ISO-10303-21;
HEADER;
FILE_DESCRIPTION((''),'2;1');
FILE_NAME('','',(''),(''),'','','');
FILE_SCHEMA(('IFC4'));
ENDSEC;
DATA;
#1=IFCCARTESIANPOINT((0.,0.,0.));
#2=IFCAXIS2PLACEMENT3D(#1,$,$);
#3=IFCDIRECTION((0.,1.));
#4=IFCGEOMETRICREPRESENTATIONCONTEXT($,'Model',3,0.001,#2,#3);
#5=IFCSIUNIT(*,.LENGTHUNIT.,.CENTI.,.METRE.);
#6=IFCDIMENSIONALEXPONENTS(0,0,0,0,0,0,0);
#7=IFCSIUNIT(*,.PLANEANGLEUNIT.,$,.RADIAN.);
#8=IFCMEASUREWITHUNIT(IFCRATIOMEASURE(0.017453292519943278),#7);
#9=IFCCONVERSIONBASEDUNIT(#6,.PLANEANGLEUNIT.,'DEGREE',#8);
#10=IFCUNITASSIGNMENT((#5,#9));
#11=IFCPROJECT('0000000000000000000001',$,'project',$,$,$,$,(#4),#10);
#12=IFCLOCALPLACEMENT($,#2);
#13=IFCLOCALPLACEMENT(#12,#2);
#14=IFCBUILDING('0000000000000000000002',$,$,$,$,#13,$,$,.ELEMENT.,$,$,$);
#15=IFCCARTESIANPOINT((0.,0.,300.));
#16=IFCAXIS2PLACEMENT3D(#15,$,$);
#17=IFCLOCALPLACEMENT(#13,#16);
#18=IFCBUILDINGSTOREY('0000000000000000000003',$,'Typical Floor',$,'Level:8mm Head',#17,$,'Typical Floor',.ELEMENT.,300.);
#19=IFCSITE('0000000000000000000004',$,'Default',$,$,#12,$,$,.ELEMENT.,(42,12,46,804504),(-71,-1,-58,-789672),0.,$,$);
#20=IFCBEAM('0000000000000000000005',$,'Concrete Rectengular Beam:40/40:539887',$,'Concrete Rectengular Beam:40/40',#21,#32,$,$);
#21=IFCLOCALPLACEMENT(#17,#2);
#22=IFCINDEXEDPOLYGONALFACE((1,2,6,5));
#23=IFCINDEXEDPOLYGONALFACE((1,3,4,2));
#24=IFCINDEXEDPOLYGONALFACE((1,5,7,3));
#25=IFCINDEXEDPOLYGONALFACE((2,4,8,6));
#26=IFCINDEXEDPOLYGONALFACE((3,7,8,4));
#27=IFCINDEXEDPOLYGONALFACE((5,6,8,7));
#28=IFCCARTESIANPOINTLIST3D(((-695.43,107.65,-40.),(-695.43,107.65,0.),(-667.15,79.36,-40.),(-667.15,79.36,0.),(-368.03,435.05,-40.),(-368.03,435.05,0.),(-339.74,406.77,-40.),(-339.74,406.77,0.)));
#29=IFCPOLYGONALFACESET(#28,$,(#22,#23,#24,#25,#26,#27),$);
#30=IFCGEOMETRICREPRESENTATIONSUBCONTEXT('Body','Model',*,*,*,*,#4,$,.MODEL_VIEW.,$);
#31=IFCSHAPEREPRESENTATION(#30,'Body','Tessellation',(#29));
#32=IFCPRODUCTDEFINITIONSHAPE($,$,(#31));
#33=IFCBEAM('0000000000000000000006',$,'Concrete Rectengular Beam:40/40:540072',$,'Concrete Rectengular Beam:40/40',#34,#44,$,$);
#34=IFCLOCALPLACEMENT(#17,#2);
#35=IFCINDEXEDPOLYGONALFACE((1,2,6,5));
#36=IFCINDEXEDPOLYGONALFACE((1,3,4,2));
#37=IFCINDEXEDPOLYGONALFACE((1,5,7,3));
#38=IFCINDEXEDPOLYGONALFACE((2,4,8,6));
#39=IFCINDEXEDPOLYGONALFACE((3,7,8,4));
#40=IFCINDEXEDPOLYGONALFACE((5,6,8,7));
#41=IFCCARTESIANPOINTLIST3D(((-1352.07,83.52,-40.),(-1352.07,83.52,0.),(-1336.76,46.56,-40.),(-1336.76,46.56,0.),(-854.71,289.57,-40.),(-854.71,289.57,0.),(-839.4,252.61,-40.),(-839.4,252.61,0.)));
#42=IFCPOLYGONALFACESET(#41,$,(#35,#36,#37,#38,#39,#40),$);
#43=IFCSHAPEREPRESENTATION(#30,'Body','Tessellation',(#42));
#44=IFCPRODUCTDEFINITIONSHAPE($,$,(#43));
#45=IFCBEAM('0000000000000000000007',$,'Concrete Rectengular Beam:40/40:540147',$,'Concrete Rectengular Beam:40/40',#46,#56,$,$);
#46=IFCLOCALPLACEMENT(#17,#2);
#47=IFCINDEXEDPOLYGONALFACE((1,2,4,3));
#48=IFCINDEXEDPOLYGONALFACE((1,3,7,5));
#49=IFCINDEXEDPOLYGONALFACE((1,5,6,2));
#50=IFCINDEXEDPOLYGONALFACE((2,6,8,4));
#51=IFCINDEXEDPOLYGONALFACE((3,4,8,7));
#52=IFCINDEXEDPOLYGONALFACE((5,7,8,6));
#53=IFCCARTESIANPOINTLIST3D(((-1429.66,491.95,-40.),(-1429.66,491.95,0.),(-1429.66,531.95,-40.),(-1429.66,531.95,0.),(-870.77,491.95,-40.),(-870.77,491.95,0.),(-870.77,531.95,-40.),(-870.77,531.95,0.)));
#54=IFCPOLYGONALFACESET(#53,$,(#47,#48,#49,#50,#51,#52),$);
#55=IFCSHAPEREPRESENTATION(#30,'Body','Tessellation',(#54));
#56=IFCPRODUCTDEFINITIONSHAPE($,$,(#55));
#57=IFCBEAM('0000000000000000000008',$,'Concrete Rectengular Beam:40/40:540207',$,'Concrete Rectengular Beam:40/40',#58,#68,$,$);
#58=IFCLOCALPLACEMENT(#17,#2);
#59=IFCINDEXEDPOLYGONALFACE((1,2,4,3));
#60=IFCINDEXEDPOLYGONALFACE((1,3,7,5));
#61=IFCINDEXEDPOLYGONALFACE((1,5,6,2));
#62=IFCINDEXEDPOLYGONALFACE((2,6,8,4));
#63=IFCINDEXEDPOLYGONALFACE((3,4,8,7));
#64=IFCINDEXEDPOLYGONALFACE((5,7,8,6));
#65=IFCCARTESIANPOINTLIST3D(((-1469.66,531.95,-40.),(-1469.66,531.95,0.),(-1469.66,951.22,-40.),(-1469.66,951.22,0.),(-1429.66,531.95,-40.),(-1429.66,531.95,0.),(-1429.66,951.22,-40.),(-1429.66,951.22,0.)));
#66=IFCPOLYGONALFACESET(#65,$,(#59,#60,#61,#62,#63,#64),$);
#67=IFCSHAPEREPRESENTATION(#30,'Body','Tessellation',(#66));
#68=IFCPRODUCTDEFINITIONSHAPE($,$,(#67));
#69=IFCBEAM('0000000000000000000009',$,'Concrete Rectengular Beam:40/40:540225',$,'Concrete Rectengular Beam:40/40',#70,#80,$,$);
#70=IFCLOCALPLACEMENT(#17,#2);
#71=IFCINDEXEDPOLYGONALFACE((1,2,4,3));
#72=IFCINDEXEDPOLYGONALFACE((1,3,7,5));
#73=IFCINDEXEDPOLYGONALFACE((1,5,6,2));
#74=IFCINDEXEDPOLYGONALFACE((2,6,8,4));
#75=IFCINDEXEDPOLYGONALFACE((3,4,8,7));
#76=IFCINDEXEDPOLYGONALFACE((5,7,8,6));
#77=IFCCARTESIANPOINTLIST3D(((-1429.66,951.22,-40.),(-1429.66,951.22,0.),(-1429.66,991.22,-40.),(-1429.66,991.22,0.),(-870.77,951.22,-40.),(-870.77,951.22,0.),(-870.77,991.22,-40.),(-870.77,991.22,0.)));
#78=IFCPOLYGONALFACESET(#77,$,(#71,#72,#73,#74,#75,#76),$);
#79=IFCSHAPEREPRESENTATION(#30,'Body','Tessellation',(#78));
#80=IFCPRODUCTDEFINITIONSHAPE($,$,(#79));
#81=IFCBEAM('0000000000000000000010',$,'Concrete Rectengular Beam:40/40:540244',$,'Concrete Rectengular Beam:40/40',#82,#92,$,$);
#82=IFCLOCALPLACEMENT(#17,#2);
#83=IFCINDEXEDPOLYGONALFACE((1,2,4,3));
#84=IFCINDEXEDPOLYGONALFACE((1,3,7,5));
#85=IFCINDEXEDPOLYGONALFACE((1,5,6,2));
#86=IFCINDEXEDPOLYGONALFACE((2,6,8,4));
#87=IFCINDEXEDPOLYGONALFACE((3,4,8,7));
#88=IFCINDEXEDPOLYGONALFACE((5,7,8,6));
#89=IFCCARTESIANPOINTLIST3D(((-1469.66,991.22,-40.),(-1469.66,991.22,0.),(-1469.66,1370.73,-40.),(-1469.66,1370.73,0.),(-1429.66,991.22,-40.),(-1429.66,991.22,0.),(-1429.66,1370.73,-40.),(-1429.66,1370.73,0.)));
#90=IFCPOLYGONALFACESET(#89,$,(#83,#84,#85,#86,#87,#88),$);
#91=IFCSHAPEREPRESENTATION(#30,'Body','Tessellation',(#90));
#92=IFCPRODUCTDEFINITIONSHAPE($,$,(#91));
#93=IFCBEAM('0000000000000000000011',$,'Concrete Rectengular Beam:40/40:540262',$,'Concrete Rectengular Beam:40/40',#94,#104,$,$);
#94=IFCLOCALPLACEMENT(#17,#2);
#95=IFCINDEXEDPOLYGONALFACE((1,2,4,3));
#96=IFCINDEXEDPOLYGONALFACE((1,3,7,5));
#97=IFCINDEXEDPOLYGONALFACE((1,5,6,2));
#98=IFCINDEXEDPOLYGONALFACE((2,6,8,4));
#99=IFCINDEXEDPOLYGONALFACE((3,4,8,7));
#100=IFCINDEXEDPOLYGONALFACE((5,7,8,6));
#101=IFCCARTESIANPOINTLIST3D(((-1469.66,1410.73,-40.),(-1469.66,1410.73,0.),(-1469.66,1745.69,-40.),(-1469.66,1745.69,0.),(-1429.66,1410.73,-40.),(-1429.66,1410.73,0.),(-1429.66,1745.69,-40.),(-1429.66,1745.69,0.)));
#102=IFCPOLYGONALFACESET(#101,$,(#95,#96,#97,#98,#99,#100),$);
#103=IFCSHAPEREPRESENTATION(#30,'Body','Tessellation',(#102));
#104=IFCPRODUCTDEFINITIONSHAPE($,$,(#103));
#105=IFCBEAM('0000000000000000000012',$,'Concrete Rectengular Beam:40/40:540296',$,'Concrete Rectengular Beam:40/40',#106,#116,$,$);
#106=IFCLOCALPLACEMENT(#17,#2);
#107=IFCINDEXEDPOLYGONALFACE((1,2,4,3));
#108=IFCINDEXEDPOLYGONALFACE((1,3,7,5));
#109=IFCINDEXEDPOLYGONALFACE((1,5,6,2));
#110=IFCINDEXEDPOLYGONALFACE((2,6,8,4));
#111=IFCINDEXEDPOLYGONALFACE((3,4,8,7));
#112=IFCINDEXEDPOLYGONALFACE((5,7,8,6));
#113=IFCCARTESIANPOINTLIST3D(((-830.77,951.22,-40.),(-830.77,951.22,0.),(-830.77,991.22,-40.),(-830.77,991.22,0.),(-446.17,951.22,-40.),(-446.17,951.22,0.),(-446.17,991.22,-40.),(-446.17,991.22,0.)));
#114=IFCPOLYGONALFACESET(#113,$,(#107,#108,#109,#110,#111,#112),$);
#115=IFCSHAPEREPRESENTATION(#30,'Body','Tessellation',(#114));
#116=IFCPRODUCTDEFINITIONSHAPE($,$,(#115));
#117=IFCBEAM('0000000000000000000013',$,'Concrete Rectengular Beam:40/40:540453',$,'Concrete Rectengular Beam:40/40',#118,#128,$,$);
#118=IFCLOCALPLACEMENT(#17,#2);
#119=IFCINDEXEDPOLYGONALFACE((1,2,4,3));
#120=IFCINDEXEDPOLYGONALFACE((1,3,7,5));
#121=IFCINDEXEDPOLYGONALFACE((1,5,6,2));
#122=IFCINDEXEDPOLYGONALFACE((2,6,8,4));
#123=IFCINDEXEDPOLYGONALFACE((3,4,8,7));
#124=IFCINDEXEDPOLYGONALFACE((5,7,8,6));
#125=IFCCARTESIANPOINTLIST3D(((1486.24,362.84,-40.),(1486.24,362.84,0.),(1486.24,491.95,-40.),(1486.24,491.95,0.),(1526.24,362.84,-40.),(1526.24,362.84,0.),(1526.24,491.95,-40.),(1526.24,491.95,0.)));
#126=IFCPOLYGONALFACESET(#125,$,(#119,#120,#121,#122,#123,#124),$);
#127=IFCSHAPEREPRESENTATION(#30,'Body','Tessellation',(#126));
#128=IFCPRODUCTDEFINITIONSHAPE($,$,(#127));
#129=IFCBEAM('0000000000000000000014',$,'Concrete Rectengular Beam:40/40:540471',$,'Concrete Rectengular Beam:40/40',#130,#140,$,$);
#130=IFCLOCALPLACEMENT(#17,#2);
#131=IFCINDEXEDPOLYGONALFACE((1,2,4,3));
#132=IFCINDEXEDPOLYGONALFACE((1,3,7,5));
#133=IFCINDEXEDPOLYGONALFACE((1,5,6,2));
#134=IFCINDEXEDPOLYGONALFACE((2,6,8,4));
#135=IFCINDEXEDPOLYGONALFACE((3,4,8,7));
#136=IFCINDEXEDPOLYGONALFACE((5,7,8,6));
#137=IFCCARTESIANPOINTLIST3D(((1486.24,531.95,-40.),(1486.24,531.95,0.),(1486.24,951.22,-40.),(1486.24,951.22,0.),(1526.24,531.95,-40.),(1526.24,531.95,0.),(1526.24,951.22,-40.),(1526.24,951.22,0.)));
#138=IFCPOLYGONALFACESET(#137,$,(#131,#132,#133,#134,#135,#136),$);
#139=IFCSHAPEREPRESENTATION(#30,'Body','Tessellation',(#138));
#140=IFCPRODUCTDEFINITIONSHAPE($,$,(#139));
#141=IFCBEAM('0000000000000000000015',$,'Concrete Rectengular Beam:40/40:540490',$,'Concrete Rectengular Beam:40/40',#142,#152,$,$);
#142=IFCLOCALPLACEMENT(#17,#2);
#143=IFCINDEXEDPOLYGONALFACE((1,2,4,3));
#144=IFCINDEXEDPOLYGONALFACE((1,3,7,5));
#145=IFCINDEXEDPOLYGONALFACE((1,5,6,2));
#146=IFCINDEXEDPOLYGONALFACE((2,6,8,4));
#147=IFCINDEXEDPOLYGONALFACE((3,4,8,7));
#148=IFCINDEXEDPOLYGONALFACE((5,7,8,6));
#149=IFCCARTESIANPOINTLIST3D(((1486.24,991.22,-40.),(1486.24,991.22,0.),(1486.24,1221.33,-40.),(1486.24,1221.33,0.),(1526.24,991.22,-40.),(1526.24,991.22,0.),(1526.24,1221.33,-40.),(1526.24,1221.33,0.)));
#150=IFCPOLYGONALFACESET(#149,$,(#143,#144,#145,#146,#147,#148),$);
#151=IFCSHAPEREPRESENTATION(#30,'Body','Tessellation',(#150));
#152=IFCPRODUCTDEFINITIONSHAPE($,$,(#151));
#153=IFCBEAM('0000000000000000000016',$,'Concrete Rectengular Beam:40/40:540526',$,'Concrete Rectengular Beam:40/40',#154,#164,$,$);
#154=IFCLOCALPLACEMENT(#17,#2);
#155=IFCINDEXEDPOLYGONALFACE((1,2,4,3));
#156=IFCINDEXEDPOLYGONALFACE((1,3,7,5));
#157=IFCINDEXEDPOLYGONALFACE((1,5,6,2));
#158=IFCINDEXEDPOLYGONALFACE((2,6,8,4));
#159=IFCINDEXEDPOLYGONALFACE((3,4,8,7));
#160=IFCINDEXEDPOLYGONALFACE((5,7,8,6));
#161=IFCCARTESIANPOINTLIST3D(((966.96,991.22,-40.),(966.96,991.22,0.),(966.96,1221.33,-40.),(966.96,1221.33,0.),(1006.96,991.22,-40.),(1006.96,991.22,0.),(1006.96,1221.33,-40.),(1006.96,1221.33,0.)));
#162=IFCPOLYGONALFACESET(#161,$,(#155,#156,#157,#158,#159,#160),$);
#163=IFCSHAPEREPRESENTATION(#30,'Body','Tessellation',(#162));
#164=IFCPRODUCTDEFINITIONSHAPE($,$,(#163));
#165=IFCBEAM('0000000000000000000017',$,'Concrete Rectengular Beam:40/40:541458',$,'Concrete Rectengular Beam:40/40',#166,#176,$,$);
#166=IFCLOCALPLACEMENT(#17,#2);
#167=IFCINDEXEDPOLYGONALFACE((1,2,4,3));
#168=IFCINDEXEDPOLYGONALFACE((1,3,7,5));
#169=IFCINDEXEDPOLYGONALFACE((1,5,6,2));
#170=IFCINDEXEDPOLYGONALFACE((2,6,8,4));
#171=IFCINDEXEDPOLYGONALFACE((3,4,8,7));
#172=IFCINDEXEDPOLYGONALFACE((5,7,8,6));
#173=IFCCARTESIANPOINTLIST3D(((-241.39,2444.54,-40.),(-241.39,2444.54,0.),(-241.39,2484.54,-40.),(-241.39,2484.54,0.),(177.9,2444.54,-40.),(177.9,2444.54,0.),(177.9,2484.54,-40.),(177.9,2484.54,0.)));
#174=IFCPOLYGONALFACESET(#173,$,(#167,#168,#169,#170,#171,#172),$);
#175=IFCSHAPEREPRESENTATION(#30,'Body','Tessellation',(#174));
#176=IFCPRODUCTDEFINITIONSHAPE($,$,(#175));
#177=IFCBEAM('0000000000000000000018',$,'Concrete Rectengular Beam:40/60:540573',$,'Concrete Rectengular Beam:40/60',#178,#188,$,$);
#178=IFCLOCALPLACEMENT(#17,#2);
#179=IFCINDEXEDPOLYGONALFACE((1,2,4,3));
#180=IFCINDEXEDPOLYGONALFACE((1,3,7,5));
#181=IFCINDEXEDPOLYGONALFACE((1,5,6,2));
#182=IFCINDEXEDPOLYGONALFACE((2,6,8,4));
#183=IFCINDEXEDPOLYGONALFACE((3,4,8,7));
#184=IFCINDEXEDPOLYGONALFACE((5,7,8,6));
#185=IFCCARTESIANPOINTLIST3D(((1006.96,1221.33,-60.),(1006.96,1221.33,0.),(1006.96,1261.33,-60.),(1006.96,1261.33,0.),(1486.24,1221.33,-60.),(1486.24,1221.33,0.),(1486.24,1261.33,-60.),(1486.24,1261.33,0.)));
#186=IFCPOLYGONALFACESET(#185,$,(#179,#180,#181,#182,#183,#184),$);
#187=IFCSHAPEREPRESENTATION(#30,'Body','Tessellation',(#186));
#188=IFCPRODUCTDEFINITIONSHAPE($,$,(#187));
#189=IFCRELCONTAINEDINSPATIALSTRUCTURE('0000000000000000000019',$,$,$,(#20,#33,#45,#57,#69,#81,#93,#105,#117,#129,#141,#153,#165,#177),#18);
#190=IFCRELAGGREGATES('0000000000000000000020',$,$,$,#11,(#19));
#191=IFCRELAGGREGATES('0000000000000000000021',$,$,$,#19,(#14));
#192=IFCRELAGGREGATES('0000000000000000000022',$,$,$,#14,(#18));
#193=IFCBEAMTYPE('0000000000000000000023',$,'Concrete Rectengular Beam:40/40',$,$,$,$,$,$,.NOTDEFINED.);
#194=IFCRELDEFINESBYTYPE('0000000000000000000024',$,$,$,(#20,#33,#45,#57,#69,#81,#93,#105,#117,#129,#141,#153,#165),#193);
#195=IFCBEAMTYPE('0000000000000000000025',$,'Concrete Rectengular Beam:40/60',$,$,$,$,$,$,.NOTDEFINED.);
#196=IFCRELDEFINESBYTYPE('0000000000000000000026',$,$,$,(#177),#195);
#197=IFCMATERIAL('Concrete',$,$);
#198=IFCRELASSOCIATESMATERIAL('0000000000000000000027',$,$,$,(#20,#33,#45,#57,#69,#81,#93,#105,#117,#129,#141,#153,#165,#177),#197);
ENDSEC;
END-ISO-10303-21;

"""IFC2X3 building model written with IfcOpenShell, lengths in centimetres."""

from ifc_helpers import new_model, entity, si_unit, converted_unit, direction, frame, frame_2d, origin, origin_2d_with_axis, place, context, subcontext, project, spatial, rectangle, extrude, material, type_object, element, save


model = new_model("IFC2X3")

# Units and contexts
model_context = context("Model", 3, precision=0.001, world=origin(), true_north=direction((0.0, 1.0)))
body_context = subcontext(model_context, "Body", "Model", "MODEL_VIEW")
ifc_project = project(units=[si_unit("LENGTHUNIT", "METRE", prefix="CENTI"), converted_unit("PLANEANGLEUNIT", "DEGREE", entity("IfcRatioMeasure", 0.017453292519943278), si_unit("PLANEANGLEUNIT", "RADIAN"), dimensions=[0, 0, 0, 0, 0, 0, 0])], contexts=[model_context])

# Site, building, storey
site_placement = place(None, origin())
site = spatial("IfcSite", under=ifc_project, at=site_placement, Name="Default", CompositionType="ELEMENT", RefLatitude=(42, 12, 46, 804504), RefLongitude=(-71, -1, -58, -789672), RefElevation=0.0)
building_placement = place(site_placement, origin())
building = spatial("IfcBuilding", under=site, at=building_placement, CompositionType="ELEMENT")
storey_placement = place(building_placement, frame((0.0, 0.0, 300.0)))
storey = spatial("IfcBuildingStorey", under=building, at=storey_placement, Name="Typical Floor", ObjectType="Level:8mm Head", LongName="Typical Floor", CompositionType="ELEMENT", Elevation=300.0)

# Beams
ifc_material = material(Name="Concrete")
beam_type_1 = type_object("IfcBeamType", Name="Concrete Rectengular Beam:40/40", PredefinedType="NOTDEFINED")
beam_1_placement = place(storey_placement, frame((-681.33, 93.46, 0.0), z_axis=(0.0, 0.0, 1.0), x_axis=(0.707109, 0.707104, 0.0)))
element("IfcBeam", 1, at=beam_1_placement, inside=storey, type_object=beam_type_1, material=ifc_material, Name="Concrete Rectengular Beam:40/40:539887", ObjectType="Concrete Rectengular Beam:40/40", context=body_context, shape_type="SweptSolid", body=[
    extrude(rectangle(XDim=40.0, YDim=40.0, at=frame_2d((0.0, 0.0), x_axis=(1.0, 0.0))), frame((0.06, 0.0, -20.0), z_axis=(1.0, 0.0, 0.0), x_axis=(0.0, 0.0, -1.0)), (0.0, 0.0, 1.0), 463.02),
])
beam_2_placement = place(storey_placement, frame((-1362.89, 57.39, 0.0), z_axis=(0.0, 0.0, 1.0), x_axis=(0.923857, 0.382737, 0.0)))
element("IfcBeam", 2, at=beam_2_placement, inside=storey, type_object=beam_type_1, material=ifc_material, Name="Concrete Rectengular Beam:40/40:540072", ObjectType="Concrete Rectengular Beam:40/40", context=body_context, shape_type="SweptSolid", body=[
    extrude(rectangle(XDim=40.0, YDim=40.0, at=frame_2d((0.0, 0.0), x_axis=(1.0, 0.0))), frame((20.0, 0.0, -20.0), z_axis=(1.0, 0.0, 0.0), x_axis=(0.0, 0.0, -1.0)), (0.0, 0.0, 1.0), 538.36),
])
beam_3_placement = place(storey_placement, frame((-1449.66, 511.95, 0.0)))
element("IfcBeam", 3, at=beam_3_placement, inside=storey, type_object=beam_type_1, material=ifc_material, Name="Concrete Rectengular Beam:40/40:540147", ObjectType="Concrete Rectengular Beam:40/40", context=body_context, shape_type="SweptSolid", body=[
    extrude(rectangle(XDim=40.0, YDim=40.0, at=frame_2d((0.0, 0.0), x_axis=(1.0, 0.0))), frame((20.0, 0.0, -20.0), z_axis=(1.0, 0.0, 0.0), x_axis=(0.0, 0.0, -1.0)), (0.0, 0.0, 1.0), 558.89),
])
beam_4_placement = place(storey_placement, frame((-1449.66, 511.95, 0.0), z_axis=(0.0, 0.0, 1.0), x_axis=(0.0, 1.0, 0.0)))
element("IfcBeam", 4, at=beam_4_placement, inside=storey, type_object=beam_type_1, material=ifc_material, Name="Concrete Rectengular Beam:40/40:540207", ObjectType="Concrete Rectengular Beam:40/40", context=body_context, shape_type="SweptSolid", body=[
    extrude(rectangle(XDim=40.0, YDim=40.0, at=frame_2d((0.0, 0.0), x_axis=(1.0, 0.0))), frame((20.0, 0.0, -20.0), z_axis=(1.0, 0.0, 0.0), x_axis=(0.0, 0.0, -1.0)), (0.0, 0.0, 1.0), 419.26),
])
beam_5_placement = place(storey_placement, frame((-1449.66, 971.22, 0.0)))
element("IfcBeam", 5, at=beam_5_placement, inside=storey, type_object=beam_type_1, material=ifc_material, Name="Concrete Rectengular Beam:40/40:540225", ObjectType="Concrete Rectengular Beam:40/40", context=body_context, shape_type="SweptSolid", body=[
    extrude(rectangle(XDim=40.0, YDim=40.0, at=frame_2d((0.0, 0.0), x_axis=(1.0, 0.0))), frame((20.0, 0.0, -20.0), z_axis=(1.0, 0.0, 0.0), x_axis=(0.0, 0.0, -1.0)), (0.0, 0.0, 1.0), 558.89),
])
beam_6_placement = place(storey_placement, frame((-1449.66, 971.22, 0.0), z_axis=(0.0, 0.0, 1.0), x_axis=(0.0, 1.0, 0.0)))
element("IfcBeam", 6, at=beam_6_placement, inside=storey, type_object=beam_type_1, material=ifc_material, Name="Concrete Rectengular Beam:40/40:540244", ObjectType="Concrete Rectengular Beam:40/40", context=body_context, shape_type="SweptSolid", body=[
    extrude(rectangle(XDim=40.0, YDim=40.0, at=origin_2d_with_axis()), frame((20.0, 0.0, -20.0), z_axis=(1.0, 0.0, 0.0), x_axis=(0.0, 0.0, -1.0)), (0.0, 0.0, 1.0), 379.52),
])
beam_7_placement = place(storey_placement, frame((-1449.66, 1390.73, 0.0), z_axis=(0.0, 0.0, 1.0), x_axis=(0.0, 1.0, 0.0)))
element("IfcBeam", 7, at=beam_7_placement, inside=storey, type_object=beam_type_1, material=ifc_material, Name="Concrete Rectengular Beam:40/40:540262", ObjectType="Concrete Rectengular Beam:40/40", context=body_context, shape_type="SweptSolid", body=[
    extrude(rectangle(XDim=40.0, YDim=40.0, at=frame_2d((0.0, 0.0), x_axis=(1.0, 0.0))), frame((20.0, 0.0, -20.0), z_axis=(1.0, 0.0, 0.0), x_axis=(0.0, 0.0, -1.0)), (0.0, 0.0, 1.0), 334.96),
])
beam_8_placement = place(storey_placement, frame((-850.77, 971.22, 0.0)))
element("IfcBeam", 8, at=beam_8_placement, inside=storey, type_object=beam_type_1, material=ifc_material, Name="Concrete Rectengular Beam:40/40:540296", ObjectType="Concrete Rectengular Beam:40/40", context=body_context, shape_type="SweptSolid", body=[
    extrude(rectangle(XDim=40.0, YDim=40.0, at=frame_2d((0.0, 0.0), x_axis=(1.0, 0.0))), frame((20.0, 0.0, -20.0), z_axis=(1.0, 0.0, 0.0), x_axis=(0.0, 0.0, -1.0)), (0.0, 0.0, 1.0), 384.6),
])
beam_9_placement = place(storey_placement, frame((1506.24, 342.84, 0.0), z_axis=(0.0, 0.0, 1.0), x_axis=(0.0, 1.0, 0.0)))
element("IfcBeam", 9, at=beam_9_placement, inside=storey, type_object=beam_type_1, material=ifc_material, Name="Concrete Rectengular Beam:40/40:540453", ObjectType="Concrete Rectengular Beam:40/40", context=body_context, shape_type="SweptSolid", body=[
    extrude(rectangle(XDim=40.0, YDim=40.0, at=origin_2d_with_axis()), frame((20.0, 0.0, -20.0), z_axis=(1.0, 0.0, 0.0), x_axis=(0.0, 0.0, -1.0)), (0.0, 0.0, 1.0), 129.11),
])
beam_10_placement = place(storey_placement, frame((1506.24, 511.95, 0.0), z_axis=(0.0, 0.0, 1.0), x_axis=(0.0, 1.0, 0.0)))
element("IfcBeam", 10, at=beam_10_placement, inside=storey, type_object=beam_type_1, material=ifc_material, Name="Concrete Rectengular Beam:40/40:540471", ObjectType="Concrete Rectengular Beam:40/40", context=body_context, shape_type="SweptSolid", body=[
    extrude(rectangle(XDim=40.0, YDim=40.0, at=origin_2d_with_axis()), frame((20.0, 0.0, -20.0), z_axis=(1.0, 0.0, 0.0), x_axis=(0.0, 0.0, -1.0)), (0.0, 0.0, 1.0), 419.26),
])
beam_11_placement = place(storey_placement, frame((1506.24, 971.22, 0.0), z_axis=(0.0, 0.0, 1.0), x_axis=(0.0, 1.0, 0.0)))
element("IfcBeam", 11, at=beam_11_placement, inside=storey, type_object=beam_type_1, material=ifc_material, Name="Concrete Rectengular Beam:40/40:540490", ObjectType="Concrete Rectengular Beam:40/40", context=body_context, shape_type="SweptSolid", body=[
    extrude(rectangle(XDim=40.0, YDim=40.0, at=frame_2d((0.0, 0.0), x_axis=(1.0, 0.0))), frame((20.0, 0.0, -20.0), z_axis=(1.0, 0.0, 0.0), x_axis=(0.0, 0.0, -1.0)), (0.0, 0.0, 1.0), 230.12),
])
beam_12_placement = place(storey_placement, frame((986.96, 971.22, 0.0), z_axis=(0.0, 0.0, 1.0), x_axis=(0.0, 1.0, 0.0)))
element("IfcBeam", 12, at=beam_12_placement, inside=storey, type_object=beam_type_1, material=ifc_material, Name="Concrete Rectengular Beam:40/40:540526", ObjectType="Concrete Rectengular Beam:40/40", context=body_context, shape_type="SweptSolid", body=[
    extrude(rectangle(XDim=40.0, YDim=40.0, at=frame_2d((0.0, 0.0), x_axis=(1.0, 0.0))), frame((20.0, 0.0, -20.0), z_axis=(1.0, 0.0, 0.0), x_axis=(0.0, 0.0, -1.0)), (0.0, 0.0, 1.0), 230.12),
])
beam_13_placement = place(storey_placement, frame((197.9, 2464.54, 0.0), z_axis=(0.0, 0.0, 1.0), x_axis=(-1.0, 0.0, 0.0)))
element("IfcBeam", 13, at=beam_13_placement, inside=storey, type_object=beam_type_1, material=ifc_material, Name="Concrete Rectengular Beam:40/40:541458", ObjectType="Concrete Rectengular Beam:40/40", context=body_context, shape_type="SweptSolid", body=[
    extrude(rectangle(XDim=40.0, YDim=40.0, at=frame_2d((0.0, 0.0), x_axis=(1.0, 0.0))), frame((20.0, 0.0, -20.0), z_axis=(1.0, 0.0, 0.0), x_axis=(0.0, 0.0, -1.0)), (0.0, 0.0, 1.0), 419.29),
])
beam_type_2 = type_object("IfcBeamType", Name="Concrete Rectengular Beam:40/60", PredefinedType="NOTDEFINED")
beam_14_placement = place(storey_placement, frame((986.96, 1241.33, 0.0)))
element("IfcBeam", 14, at=beam_14_placement, inside=storey, type_object=beam_type_2, material=ifc_material, Name="Concrete Rectengular Beam:40/60:540573", ObjectType="Concrete Rectengular Beam:40/60", context=body_context, shape_type="SweptSolid", body=[
    extrude(rectangle(XDim=60.0, YDim=40.0, at=frame_2d((0.0, 0.0), x_axis=(1.0, 0.0))), frame((20.0, 0.0, -30.0), z_axis=(1.0, 0.0, 0.0), x_axis=(0.0, 0.0, -1.0)), (0.0, 0.0, 1.0), 479.27),
])

save(model, "model.ifc")
